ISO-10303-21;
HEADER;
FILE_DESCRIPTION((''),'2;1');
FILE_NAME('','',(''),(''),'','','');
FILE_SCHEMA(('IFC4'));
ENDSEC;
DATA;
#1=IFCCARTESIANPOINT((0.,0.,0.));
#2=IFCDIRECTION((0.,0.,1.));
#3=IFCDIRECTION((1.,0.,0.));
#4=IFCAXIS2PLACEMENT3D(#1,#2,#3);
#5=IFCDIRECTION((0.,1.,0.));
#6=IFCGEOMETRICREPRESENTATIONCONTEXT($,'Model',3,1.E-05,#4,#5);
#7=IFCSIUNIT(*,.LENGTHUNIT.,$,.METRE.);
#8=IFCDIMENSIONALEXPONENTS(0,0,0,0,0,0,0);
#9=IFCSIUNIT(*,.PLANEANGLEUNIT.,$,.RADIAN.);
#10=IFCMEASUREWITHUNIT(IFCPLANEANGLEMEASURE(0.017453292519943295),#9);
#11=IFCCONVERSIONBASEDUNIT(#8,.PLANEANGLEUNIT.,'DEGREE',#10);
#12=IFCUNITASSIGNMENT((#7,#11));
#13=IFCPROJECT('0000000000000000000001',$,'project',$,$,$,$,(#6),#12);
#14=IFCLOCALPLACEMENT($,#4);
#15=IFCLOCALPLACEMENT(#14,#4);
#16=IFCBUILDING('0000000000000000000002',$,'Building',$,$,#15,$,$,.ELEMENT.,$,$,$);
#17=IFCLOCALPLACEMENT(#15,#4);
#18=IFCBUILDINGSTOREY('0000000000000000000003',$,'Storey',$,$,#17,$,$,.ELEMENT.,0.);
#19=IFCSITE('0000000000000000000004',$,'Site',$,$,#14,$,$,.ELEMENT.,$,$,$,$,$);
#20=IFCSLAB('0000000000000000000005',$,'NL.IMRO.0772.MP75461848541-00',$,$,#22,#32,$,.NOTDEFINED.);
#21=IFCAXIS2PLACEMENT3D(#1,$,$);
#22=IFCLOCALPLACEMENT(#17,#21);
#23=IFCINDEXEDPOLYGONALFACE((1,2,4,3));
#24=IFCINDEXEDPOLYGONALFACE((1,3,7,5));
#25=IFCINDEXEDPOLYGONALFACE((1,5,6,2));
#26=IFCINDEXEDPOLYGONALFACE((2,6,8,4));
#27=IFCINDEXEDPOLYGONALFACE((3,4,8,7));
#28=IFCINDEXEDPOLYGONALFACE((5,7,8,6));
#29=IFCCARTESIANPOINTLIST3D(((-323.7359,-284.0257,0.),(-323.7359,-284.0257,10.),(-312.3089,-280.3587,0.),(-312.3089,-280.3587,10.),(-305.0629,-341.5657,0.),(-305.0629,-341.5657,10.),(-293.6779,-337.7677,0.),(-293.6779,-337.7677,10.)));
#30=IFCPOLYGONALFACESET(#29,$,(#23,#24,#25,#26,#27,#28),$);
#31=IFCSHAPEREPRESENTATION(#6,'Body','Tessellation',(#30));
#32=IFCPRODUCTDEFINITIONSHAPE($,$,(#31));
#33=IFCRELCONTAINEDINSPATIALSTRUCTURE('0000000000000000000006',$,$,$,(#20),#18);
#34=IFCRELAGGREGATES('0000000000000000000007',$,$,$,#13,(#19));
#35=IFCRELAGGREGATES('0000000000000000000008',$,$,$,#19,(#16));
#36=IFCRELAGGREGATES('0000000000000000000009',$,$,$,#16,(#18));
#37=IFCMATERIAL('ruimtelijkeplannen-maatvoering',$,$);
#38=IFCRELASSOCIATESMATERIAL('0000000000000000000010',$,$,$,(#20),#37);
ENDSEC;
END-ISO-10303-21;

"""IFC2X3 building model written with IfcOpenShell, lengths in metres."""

from ifc_helpers import new_model, entity, si_unit, converted_unit, direction, origin_with_axes, place, context, project, spatial, polyline, outline, extrude, material, element, save


model = new_model("IFC2X3")

# Units and contexts
model_context = context("Model", 3, precision=1e-05, world=origin_with_axes(), true_north=direction((0.0, 1.0, 0.0)))
ifc_project = project(units=[si_unit("LENGTHUNIT", "METRE"), converted_unit("PLANEANGLEUNIT", "DEGREE", entity("IfcPlaneAngleMeasure", 0.017453292519943295), si_unit("PLANEANGLEUNIT", "RADIAN"), dimensions=[0, 0, 0, 0, 0, 0, 0])], contexts=[model_context])

# Site, building, storey
site_placement = place(None, origin_with_axes())
site = spatial("IfcSite", under=ifc_project, at=site_placement, Name="Site", CompositionType="ELEMENT")
building_placement = place(site_placement, origin_with_axes())
building = spatial("IfcBuilding", under=site, at=building_placement, Name="Building", CompositionType="ELEMENT")
storey_placement = place(building_placement, origin_with_axes())
storey = spatial("IfcBuildingStorey", under=building, at=storey_placement, Name="Storey", CompositionType="ELEMENT", Elevation=0.0)

# Slab
ifc_material_1 = material(Name="ruimtelijkeplannen-maatvoering")
slab_1_placement = place(storey_placement, origin_with_axes())
element("IfcSlab", 1, at=slab_1_placement, inside=storey, material=ifc_material_1, Name="NL.IMRO.0772.MP75461848541-00", PredefinedType="NOTDEFINED", context=model_context, shape_type="SweptSolid", body=[
    extrude(outline(polyline([(-305.0629, -341.5657), (-323.7359, -284.0257), (-312.3089, -280.3587), (-293.6779, -337.7677), (-305.0629, -341.5657)])), origin_with_axes(), (0.0, 0.0, 1.0), 10.0),
])

save(model, "model.ifc")
